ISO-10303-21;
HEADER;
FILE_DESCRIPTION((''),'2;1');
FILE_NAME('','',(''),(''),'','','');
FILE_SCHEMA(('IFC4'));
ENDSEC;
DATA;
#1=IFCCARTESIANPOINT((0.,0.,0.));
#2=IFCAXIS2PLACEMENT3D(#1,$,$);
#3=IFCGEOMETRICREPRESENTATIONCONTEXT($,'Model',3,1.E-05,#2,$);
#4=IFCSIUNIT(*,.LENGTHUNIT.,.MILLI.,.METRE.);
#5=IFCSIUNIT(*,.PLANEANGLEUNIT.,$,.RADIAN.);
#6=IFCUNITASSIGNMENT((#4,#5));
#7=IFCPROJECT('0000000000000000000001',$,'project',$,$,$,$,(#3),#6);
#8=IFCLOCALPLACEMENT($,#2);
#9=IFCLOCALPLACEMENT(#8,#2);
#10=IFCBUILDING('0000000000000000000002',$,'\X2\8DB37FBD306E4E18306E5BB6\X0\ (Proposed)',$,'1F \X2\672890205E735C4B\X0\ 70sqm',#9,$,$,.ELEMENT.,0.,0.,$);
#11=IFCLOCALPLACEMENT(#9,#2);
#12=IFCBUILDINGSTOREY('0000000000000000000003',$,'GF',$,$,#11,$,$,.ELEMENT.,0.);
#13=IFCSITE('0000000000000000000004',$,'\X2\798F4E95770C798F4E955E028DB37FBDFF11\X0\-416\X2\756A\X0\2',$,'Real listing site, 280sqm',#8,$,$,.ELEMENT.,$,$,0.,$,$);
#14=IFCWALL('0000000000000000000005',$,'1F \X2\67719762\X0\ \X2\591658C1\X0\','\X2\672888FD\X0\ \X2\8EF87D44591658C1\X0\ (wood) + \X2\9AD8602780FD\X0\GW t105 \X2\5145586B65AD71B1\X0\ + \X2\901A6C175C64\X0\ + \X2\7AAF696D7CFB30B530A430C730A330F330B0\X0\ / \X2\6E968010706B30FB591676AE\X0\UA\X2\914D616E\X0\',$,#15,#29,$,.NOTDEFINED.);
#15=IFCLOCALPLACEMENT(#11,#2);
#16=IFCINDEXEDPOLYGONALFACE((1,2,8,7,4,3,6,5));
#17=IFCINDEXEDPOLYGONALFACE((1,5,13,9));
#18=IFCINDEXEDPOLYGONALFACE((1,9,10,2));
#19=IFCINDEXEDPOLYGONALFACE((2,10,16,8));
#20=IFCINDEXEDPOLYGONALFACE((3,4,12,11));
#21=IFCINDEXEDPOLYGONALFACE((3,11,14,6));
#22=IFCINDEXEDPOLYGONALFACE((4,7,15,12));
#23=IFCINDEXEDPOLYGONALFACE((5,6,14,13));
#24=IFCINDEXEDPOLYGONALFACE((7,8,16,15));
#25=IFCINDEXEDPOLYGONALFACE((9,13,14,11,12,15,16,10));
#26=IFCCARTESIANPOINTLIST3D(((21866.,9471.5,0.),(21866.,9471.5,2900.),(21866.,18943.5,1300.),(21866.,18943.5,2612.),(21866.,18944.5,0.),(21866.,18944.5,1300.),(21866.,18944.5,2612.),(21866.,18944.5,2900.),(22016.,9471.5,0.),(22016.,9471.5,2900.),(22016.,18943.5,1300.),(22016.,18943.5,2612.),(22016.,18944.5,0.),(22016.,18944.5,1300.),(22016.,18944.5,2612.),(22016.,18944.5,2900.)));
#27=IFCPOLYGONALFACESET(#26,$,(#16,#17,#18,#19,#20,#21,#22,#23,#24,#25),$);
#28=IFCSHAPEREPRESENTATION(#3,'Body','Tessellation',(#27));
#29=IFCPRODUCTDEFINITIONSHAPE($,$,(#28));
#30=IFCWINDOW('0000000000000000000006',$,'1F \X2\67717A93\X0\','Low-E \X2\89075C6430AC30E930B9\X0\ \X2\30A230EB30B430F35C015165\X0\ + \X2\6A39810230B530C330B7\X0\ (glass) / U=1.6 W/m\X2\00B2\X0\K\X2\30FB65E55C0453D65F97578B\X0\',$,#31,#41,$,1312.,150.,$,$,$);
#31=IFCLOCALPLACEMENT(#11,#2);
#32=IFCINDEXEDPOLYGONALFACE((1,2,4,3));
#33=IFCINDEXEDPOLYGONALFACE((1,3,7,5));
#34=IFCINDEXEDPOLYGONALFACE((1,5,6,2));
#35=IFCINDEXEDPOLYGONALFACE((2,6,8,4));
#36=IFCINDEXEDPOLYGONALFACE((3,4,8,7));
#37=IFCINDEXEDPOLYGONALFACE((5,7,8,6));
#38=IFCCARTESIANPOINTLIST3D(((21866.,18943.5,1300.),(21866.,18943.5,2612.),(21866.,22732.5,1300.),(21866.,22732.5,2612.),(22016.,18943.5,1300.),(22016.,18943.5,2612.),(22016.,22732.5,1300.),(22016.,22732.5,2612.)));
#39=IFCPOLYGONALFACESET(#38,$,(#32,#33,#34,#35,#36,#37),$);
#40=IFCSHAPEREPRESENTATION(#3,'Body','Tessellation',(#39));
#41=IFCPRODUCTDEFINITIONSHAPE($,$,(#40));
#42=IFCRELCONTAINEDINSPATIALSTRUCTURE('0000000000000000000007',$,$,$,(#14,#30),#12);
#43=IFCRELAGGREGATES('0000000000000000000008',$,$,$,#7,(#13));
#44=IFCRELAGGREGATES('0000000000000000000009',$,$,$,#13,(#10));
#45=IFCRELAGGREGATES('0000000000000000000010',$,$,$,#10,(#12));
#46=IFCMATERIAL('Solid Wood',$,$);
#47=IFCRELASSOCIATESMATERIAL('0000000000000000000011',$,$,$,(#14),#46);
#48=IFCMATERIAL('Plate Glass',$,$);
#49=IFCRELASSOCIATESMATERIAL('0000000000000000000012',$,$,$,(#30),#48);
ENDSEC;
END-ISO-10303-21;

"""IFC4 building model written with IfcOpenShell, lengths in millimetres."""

from ifc_helpers import new_model, si_unit, frame, frame_2d, origin, place, context, project, spatial, rectangle, extrude, material, element, fill, save


model = new_model("IFC4")

# Units and contexts
model_context = context("Model", 3, precision=1e-05, world=origin())
ifc_project = project(units=[si_unit("LENGTHUNIT", "METRE", prefix="MILLI"), si_unit("PLANEANGLEUNIT", "RADIAN")], contexts=[model_context])

# Site, building, storey
site_placement = place(None, origin())
site = spatial("IfcSite", under=ifc_project, at=site_placement, Name="福井県福井市足羽１-416番2", ObjectType="Real listing site, 280sqm", CompositionType="ELEMENT", RefElevation=0.0)
building_placement = place(site_placement, origin())
building = spatial("IfcBuilding", under=site, at=building_placement, Name="足羽の丘の家 (Proposed)", ObjectType="1F 木造平屋 70sqm", CompositionType="ELEMENT", ElevationOfRefHeight=0.0, ElevationOfTerrain=0.0)
storey_placement = place(building_placement, origin())
storey = spatial("IfcBuildingStorey", under=building, at=storey_placement, Name="GF", CompositionType="ELEMENT", Elevation=0.0)

# Shared definitions
ifc_material_1 = material(Name="Solid Wood")

# Wall, opening, window
wall_1_placement = place(storey_placement, frame((10933.0, 4736.0, 0.0)))
wall_1 = element("IfcWall", 1, at=wall_1_placement, inside=storey, material=ifc_material_1, Name="1F 東面 外壁", Description="木製 軸組外壁 (wood) + 高性能GW t105 充填断熱 + 通気層 + 窯業系サイディング / 準耐火・外皮UA配慮", PredefinedType="NOTDEFINED", context=model_context, shape_type="SweptSolid", body=[
    extrude(rectangle(XDim=150.0, YDim=9473.0, at=frame_2d((75.0, 4736.0))), frame((10933.0, 4736.0, 0.0)), (0.0, 0.0, 1.0), 2900.0),
])
opening_placement = place(storey_placement, frame((10933.0, 9472.0, 650.0)))
opening = element("IfcOpeningElement", 2, at=opening_placement, cuts=wall_1, PredefinedType="NOTDEFINED", context=model_context, shape_type="SweptSolid", body=[
    extrude(rectangle(XDim=150.0, YDim=3789.0, at=frame_2d((75.0, 1894.0))), frame((10933.0, 9472.0, 650.0)), (0.0, 0.0, 1.0), 1312.0),
])
ifc_material_2 = material(Name="Plate Glass")
window_placement = place(storey_placement, frame((10933.0, 9472.0, 650.0)))
window = element("IfcWindow", 3, at=window_placement, inside=storey, material=ifc_material_2, Name="1F 東窓", Description="Low-E 複層ガラス アルゴン封入 + 樹脂サッシ (glass) / U=1.6 W/m²K・日射取得型", OverallHeight=1312.0, OverallWidth=150.0, context=model_context, shape_type="SweptSolid", body=[
    extrude(rectangle(XDim=150.0, YDim=3789.0, at=frame_2d((75.0, 1894.0))), frame((10933.0, 9472.0, 650.0)), (0.0, 0.0, 1.0), 1312.0),
])
fill(opening, window)

save(model, "model.ifc")
